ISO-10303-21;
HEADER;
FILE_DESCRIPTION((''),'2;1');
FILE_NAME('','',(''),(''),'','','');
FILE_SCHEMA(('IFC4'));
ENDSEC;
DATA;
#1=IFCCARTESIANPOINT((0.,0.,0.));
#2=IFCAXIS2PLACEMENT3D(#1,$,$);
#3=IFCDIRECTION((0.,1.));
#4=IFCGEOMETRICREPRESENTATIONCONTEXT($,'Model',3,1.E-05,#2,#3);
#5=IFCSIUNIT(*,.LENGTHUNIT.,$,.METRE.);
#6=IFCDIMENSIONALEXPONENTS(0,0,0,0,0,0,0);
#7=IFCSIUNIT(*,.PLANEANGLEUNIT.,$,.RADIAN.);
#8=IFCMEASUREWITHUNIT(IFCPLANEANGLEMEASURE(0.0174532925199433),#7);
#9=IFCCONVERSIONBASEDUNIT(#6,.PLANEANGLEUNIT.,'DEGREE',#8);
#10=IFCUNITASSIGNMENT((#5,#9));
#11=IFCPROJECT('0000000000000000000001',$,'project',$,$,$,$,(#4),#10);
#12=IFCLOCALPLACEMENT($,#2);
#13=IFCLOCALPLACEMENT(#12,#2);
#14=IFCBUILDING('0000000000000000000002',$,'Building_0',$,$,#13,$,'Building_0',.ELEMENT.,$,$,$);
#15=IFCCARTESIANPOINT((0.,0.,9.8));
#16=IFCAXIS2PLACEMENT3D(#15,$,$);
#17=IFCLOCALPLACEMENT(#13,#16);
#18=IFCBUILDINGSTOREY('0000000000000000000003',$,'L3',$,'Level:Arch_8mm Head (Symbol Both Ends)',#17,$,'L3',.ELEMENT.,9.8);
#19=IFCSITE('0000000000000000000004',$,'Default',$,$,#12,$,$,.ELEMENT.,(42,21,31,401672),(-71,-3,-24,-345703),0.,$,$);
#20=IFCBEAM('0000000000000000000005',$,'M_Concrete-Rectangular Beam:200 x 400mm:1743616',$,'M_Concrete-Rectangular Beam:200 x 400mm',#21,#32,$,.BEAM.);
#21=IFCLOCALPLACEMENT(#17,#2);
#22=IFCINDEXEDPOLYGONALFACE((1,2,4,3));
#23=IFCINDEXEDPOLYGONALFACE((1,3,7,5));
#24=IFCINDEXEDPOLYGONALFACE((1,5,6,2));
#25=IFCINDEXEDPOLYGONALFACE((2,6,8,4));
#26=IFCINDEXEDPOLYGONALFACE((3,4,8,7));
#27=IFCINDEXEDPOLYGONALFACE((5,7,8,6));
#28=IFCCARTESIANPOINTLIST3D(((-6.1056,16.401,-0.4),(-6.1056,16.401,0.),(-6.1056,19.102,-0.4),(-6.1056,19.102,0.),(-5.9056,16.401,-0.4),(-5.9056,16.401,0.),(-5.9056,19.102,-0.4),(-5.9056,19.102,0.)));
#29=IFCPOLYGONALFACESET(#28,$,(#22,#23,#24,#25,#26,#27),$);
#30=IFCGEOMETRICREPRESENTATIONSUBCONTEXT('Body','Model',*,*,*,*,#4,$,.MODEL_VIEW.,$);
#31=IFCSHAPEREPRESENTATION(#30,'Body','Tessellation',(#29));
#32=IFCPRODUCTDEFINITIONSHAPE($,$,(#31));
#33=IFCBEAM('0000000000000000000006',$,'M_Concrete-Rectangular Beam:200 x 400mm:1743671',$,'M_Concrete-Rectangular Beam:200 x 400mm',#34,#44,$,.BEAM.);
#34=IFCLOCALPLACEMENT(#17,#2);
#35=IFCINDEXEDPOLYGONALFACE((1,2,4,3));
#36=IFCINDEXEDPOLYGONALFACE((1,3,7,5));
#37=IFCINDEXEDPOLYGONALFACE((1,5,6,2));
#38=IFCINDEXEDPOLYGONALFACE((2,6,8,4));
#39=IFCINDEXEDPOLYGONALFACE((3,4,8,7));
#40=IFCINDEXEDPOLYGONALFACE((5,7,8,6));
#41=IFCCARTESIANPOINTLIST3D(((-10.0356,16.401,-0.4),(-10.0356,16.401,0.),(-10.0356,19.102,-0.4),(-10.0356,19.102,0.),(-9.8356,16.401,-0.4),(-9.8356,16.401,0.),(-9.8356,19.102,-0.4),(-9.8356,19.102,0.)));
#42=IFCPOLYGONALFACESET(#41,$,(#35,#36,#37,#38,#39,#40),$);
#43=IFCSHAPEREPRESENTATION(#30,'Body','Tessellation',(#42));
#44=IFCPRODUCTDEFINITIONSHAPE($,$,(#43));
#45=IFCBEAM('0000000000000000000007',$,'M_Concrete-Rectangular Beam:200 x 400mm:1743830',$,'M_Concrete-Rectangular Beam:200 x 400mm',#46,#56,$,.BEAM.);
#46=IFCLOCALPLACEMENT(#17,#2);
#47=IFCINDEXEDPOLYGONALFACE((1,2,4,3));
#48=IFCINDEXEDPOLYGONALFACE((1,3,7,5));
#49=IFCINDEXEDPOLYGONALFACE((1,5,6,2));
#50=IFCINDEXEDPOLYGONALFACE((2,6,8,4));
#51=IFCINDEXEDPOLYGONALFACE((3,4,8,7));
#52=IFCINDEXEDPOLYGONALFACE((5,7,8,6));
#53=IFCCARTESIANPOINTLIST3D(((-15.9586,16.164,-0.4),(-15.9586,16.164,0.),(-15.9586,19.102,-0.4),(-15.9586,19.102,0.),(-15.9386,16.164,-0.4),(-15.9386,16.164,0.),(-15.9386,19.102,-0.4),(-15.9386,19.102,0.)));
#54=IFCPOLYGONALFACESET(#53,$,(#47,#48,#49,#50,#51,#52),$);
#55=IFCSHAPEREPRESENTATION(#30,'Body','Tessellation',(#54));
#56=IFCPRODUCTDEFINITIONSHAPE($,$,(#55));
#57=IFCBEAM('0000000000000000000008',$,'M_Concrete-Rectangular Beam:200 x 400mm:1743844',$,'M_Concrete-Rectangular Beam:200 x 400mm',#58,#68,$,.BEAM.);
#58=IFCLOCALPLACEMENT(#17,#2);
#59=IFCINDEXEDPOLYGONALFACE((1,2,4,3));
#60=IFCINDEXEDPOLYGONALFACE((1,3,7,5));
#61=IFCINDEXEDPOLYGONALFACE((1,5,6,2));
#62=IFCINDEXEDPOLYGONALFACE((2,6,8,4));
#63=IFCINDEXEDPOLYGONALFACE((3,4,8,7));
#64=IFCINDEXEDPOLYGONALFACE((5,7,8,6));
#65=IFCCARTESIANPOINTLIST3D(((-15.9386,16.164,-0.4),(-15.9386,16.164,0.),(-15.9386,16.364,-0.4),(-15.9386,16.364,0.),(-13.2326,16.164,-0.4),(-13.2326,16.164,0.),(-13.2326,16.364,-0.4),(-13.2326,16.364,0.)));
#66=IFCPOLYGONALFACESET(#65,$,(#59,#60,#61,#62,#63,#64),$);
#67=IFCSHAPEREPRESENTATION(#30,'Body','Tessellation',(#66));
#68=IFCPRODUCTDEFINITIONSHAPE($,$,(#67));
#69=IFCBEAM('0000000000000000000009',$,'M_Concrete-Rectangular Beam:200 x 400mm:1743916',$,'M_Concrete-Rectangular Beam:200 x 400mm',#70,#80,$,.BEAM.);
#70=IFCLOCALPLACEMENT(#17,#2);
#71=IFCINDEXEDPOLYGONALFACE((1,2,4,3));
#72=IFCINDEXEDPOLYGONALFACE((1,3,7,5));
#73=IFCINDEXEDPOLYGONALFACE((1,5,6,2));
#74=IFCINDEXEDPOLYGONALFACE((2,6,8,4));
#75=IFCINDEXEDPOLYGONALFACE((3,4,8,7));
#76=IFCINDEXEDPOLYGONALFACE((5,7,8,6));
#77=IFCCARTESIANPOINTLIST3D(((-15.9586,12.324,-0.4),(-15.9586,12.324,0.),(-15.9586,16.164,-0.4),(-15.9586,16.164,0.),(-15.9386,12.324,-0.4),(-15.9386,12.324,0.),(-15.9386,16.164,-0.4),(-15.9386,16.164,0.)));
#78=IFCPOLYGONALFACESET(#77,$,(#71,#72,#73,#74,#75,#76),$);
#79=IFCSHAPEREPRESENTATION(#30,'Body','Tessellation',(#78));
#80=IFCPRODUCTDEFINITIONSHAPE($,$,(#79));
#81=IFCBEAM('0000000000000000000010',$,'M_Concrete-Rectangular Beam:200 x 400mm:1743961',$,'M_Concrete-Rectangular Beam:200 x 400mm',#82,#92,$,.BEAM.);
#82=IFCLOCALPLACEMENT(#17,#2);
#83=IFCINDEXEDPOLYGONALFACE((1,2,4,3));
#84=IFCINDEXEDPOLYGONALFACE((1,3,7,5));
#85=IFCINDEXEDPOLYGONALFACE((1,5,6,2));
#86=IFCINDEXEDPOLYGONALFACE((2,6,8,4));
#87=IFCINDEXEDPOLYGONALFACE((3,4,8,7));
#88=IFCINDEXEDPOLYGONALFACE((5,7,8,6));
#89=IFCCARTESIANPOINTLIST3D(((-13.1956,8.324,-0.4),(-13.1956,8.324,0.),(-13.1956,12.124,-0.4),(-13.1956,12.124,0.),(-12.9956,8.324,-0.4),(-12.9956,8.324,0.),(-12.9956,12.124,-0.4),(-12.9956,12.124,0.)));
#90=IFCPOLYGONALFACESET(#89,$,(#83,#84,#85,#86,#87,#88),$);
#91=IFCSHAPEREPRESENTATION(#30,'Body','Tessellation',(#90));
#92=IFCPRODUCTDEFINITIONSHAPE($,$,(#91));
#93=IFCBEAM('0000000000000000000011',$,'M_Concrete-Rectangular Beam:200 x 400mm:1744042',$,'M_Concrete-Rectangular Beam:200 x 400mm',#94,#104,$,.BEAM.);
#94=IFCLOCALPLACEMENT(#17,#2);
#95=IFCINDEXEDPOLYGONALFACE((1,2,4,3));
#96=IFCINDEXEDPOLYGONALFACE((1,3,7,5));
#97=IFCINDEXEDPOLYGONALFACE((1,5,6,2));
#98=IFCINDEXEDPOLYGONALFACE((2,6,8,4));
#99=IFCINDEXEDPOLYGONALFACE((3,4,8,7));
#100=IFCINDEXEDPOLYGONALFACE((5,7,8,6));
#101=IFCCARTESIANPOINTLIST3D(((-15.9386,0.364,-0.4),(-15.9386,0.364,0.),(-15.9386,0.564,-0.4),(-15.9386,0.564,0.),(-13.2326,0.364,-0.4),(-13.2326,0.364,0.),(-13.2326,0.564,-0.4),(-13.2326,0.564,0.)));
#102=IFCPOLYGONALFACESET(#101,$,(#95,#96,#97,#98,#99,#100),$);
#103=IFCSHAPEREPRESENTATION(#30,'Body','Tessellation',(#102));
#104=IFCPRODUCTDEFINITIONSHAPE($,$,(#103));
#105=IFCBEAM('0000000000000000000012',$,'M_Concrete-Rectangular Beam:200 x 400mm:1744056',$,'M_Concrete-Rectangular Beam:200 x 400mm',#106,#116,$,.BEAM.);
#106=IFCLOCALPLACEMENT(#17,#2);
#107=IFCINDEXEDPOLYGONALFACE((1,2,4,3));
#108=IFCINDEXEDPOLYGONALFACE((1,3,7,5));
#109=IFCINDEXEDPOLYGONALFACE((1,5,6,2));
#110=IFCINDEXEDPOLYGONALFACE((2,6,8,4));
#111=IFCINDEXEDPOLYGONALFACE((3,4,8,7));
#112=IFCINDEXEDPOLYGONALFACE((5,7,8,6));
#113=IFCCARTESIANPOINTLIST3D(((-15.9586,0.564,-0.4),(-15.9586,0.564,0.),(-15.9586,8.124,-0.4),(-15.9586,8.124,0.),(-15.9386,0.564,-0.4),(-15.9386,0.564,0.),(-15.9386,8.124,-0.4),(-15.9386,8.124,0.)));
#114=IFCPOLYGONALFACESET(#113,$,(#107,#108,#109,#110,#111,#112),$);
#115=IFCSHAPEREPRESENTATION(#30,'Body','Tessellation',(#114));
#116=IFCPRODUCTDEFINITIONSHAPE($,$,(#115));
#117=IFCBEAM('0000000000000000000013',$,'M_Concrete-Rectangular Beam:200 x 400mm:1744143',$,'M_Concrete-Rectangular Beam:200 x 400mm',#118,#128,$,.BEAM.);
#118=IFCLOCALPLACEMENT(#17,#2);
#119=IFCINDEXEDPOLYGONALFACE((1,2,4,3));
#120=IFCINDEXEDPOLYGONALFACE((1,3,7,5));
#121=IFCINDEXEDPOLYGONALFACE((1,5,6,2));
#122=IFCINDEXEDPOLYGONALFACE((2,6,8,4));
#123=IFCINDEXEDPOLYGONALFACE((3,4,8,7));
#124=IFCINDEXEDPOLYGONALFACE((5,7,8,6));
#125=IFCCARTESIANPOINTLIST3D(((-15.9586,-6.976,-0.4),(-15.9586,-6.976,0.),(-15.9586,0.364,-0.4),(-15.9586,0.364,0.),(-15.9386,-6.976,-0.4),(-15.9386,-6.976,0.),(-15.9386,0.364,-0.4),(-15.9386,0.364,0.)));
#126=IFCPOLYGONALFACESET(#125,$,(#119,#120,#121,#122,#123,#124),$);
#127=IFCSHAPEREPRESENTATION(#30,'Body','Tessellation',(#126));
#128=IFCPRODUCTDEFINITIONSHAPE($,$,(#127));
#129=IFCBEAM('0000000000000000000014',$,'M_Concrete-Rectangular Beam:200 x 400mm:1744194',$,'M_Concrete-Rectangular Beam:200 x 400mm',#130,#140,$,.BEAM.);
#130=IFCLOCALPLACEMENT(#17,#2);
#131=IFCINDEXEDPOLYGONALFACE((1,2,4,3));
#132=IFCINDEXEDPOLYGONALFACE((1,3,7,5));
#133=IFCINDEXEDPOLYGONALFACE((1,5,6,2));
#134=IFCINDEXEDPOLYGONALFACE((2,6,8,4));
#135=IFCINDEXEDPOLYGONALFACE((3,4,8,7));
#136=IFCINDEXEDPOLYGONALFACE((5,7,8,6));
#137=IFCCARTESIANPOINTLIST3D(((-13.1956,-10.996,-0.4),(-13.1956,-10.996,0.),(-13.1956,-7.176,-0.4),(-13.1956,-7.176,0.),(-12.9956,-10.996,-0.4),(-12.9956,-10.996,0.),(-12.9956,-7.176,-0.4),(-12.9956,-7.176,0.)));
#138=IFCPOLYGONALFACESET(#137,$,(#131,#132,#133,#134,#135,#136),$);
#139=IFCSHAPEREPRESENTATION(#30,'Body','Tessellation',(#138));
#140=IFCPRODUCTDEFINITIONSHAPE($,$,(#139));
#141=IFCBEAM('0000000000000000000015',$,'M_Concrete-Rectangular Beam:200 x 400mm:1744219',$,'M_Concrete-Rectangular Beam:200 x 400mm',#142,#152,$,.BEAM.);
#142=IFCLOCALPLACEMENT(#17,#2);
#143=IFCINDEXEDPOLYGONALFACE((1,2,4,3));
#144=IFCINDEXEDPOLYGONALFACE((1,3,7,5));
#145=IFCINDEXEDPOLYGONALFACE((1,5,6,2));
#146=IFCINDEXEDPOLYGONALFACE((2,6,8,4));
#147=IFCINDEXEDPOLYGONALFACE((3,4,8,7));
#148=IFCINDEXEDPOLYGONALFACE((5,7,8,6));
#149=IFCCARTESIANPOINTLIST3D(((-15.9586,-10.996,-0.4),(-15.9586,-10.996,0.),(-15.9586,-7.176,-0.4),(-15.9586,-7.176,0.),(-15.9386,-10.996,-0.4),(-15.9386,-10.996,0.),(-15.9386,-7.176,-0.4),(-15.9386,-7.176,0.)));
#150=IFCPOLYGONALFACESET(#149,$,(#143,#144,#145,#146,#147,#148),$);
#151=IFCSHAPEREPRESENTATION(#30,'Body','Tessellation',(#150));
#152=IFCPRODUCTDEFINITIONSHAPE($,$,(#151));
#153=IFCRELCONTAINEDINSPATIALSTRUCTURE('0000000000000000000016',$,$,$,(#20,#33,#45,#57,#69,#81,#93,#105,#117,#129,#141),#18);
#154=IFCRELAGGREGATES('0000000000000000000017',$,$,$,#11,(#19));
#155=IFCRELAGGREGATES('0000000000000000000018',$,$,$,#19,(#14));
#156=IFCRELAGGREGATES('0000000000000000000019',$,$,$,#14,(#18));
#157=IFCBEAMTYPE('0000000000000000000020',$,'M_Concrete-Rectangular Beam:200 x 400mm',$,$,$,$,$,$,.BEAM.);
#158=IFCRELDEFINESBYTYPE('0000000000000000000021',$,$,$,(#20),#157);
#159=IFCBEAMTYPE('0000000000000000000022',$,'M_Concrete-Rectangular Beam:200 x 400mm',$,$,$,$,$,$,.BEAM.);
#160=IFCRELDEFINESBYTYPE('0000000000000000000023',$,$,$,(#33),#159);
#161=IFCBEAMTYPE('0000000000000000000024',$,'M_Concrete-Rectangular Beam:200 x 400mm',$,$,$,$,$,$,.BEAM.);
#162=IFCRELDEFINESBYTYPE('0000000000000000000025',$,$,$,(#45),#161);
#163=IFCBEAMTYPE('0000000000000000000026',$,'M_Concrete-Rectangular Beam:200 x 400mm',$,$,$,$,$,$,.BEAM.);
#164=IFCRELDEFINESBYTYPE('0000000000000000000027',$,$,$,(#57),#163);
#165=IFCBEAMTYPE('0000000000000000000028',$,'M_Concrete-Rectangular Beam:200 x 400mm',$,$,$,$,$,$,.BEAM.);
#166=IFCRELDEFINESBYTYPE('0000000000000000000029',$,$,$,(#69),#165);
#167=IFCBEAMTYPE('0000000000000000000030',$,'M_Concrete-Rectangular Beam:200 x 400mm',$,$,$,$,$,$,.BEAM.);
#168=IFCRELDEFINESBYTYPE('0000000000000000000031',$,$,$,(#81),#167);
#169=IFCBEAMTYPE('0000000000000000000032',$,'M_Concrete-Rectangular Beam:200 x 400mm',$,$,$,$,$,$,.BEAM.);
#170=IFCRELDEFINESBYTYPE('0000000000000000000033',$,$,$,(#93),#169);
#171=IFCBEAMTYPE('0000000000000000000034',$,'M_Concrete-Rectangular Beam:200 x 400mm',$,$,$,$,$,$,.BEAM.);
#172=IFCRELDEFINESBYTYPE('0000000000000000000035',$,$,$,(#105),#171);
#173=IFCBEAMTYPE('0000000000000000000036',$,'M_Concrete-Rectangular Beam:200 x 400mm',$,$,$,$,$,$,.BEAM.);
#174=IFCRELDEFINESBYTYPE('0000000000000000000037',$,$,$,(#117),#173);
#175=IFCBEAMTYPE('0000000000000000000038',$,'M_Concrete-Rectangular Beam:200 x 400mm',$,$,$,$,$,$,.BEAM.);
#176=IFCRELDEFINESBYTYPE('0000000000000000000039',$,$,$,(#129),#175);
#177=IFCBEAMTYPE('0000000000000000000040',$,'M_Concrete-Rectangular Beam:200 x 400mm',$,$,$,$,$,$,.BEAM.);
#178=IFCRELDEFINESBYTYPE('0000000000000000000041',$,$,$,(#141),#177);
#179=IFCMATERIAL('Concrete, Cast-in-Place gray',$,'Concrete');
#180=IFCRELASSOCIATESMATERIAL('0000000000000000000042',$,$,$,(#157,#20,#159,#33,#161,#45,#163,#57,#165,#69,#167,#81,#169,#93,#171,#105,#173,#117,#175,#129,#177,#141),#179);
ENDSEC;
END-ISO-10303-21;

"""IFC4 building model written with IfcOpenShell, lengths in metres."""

from ifc_helpers import new_model, entity, si_unit, converted_unit, direction, frame, origin, place, context, subcontext, project, spatial, indexed_curve, outline, extrude, source, transform, mapped, material, type_object, type_shapes, element, save


model = new_model("IFC4")

# Units and contexts
model_context = context("Model", 3, precision=1e-05, world=origin(), true_north=direction((0.0, 1.0)))
body_context = subcontext(model_context, "Body", "Model", "MODEL_VIEW")
ifc_project = project(units=[si_unit("LENGTHUNIT", "METRE"), converted_unit("PLANEANGLEUNIT", "DEGREE", entity("IfcPlaneAngleMeasure", 0.0174532925199433), si_unit("PLANEANGLEUNIT", "RADIAN"), dimensions=[0, 0, 0, 0, 0, 0, 0])], contexts=[model_context])

# Site, building, storey
site_placement = place(None, origin())
site = spatial("IfcSite", under=ifc_project, at=site_placement, Name="Default", CompositionType="ELEMENT", RefLatitude=(42, 21, 31, 401672), RefLongitude=(-71, -3, -24, -345703), RefElevation=0.0)
building_placement = place(site_placement, origin())
building = spatial("IfcBuilding", under=site, at=building_placement, Name="Building_0", LongName="Building_0", CompositionType="ELEMENT")
storey_placement = place(building_placement, frame((0.0, 0.0, 9.8)))
storey = spatial("IfcBuildingStorey", under=building, at=storey_placement, Name="L3", ObjectType="Level:Arch_8mm Head (Symbol Both Ends)", LongName="L3", CompositionType="ELEMENT", Elevation=9.8)

# Beams
ifc_material = material(Name="Concrete, Cast-in-Place gray", Category="Concrete")
beam_type_1 = type_object("IfcBeamType", Name="M_Concrete-Rectangular Beam:200 x 400mm", PredefinedType="BEAM", material=ifc_material)
shared_shape_1 = source(origin(), body_context, "Body", "SweptSolid", [
    extrude(outline(indexed_curve([(-0.1, -0.2), (0.1, -0.2), (0.1, 0.2), (-0.1, 0.2), (-0.1, -0.2)], self_intersect=False)), frame((-6.0056, 16.401, 9.6), z_axis=(0.0, 1.0, 0.0), x_axis=(-1.0, 0.0, 0.0)), (0.0, 0.0, 1.0), 2.701),
])
type_shapes(beam_type_1, [shared_shape_1])
beam_1_placement = place(storey_placement, frame((0.0, 0.0, -9.8)))
element("IfcBeam", 1, at=beam_1_placement, inside=storey, type_object=beam_type_1, material=ifc_material, Name="M_Concrete-Rectangular Beam:200 x 400mm:1743616", ObjectType="M_Concrete-Rectangular Beam:200 x 400mm", PredefinedType="BEAM", context=body_context, shape_type="MappedRepresentation", body=[
    mapped(shared_shape_1, transform((0.0, 0.0, 0.0), scale=1.0)),
])
beam_type_2 = type_object("IfcBeamType", Name="M_Concrete-Rectangular Beam:200 x 400mm", PredefinedType="BEAM", material=ifc_material)
shared_shape_2 = source(origin(), body_context, "Body", "SweptSolid", [
    extrude(outline(indexed_curve([(-0.1, -0.2), (0.1, -0.2), (0.1, 0.2), (-0.1, 0.2), (-0.1, -0.2)], self_intersect=False)), frame((-9.9356, 16.401, 9.6), z_axis=(0.0, 1.0, 0.0), x_axis=(-1.0, 0.0, 0.0)), (0.0, 0.0, 1.0), 2.701),
])
type_shapes(beam_type_2, [shared_shape_2])
beam_2_placement = place(storey_placement, frame((0.0, 0.0, -9.8)))
element("IfcBeam", 2, at=beam_2_placement, inside=storey, type_object=beam_type_2, material=ifc_material, Name="M_Concrete-Rectangular Beam:200 x 400mm:1743671", ObjectType="M_Concrete-Rectangular Beam:200 x 400mm", PredefinedType="BEAM", context=body_context, shape_type="MappedRepresentation", body=[
    mapped(shared_shape_2, transform((0.0, 0.0, 0.0), scale=1.0)),
])
beam_type_3 = type_object("IfcBeamType", Name="M_Concrete-Rectangular Beam:200 x 400mm", PredefinedType="BEAM", material=ifc_material)
shared_shape_3 = source(origin(), body_context, "Body", "SweptSolid", [
    extrude(outline(indexed_curve([(-0.01, -0.2), (0.01, -0.2), (0.01, 0.2), (-0.01, 0.2), (-0.01, -0.2)], self_intersect=False)), frame((-15.9486, 19.102, 9.6), z_axis=(0.0, -1.0, 0.0), x_axis=(-1.0, 0.0, 0.0)), (0.0, 0.0, 1.0), 2.938),
])
type_shapes(beam_type_3, [shared_shape_3])
beam_3_placement = place(storey_placement, frame((0.0, 0.0, -9.8)))
element("IfcBeam", 3, at=beam_3_placement, inside=storey, type_object=beam_type_3, material=ifc_material, Name="M_Concrete-Rectangular Beam:200 x 400mm:1743830", ObjectType="M_Concrete-Rectangular Beam:200 x 400mm", PredefinedType="BEAM", context=body_context, shape_type="MappedRepresentation", body=[
    mapped(shared_shape_3, transform((0.0, 0.0, 0.0), scale=1.0)),
])
beam_type_4 = type_object("IfcBeamType", Name="M_Concrete-Rectangular Beam:200 x 400mm", PredefinedType="BEAM", material=ifc_material)
shared_shape_4 = source(origin(), body_context, "Body", "SweptSolid", [
    extrude(outline(indexed_curve([(-0.2, -0.1), (0.2, -0.1), (0.2, 0.1), (-0.2, 0.1), (-0.2, -0.1)], self_intersect=False)), frame((-15.9386, 16.264, 9.6), z_axis=(1.0, 0.0, 0.0), x_axis=(0.0, 0.0, -1.0)), (0.0, 0.0, 1.0), 2.706),
])
type_shapes(beam_type_4, [shared_shape_4])
beam_4_placement = place(storey_placement, frame((0.0, 0.0, -9.8)))
element("IfcBeam", 4, at=beam_4_placement, inside=storey, type_object=beam_type_4, material=ifc_material, Name="M_Concrete-Rectangular Beam:200 x 400mm:1743844", ObjectType="M_Concrete-Rectangular Beam:200 x 400mm", PredefinedType="BEAM", context=body_context, shape_type="MappedRepresentation", body=[
    mapped(shared_shape_4, transform((0.0, 0.0, 0.0), scale=1.0)),
])
beam_type_5 = type_object("IfcBeamType", Name="M_Concrete-Rectangular Beam:200 x 400mm", PredefinedType="BEAM", material=ifc_material)
shared_shape_5 = source(origin(), body_context, "Body", "SweptSolid", [
    extrude(outline(indexed_curve([(-0.01, -0.2), (0.01, -0.2), (0.01, 0.2), (-0.01, 0.2), (-0.01, -0.2)], self_intersect=False)), frame((-15.9486, 12.324, 9.6), z_axis=(0.0, 1.0, 0.0), x_axis=(-1.0, 0.0, 0.0)), (0.0, 0.0, 1.0), 3.84),
])
type_shapes(beam_type_5, [shared_shape_5])
beam_5_placement = place(storey_placement, frame((0.0, 0.0, -9.8)))
element("IfcBeam", 5, at=beam_5_placement, inside=storey, type_object=beam_type_5, material=ifc_material, Name="M_Concrete-Rectangular Beam:200 x 400mm:1743916", ObjectType="M_Concrete-Rectangular Beam:200 x 400mm", PredefinedType="BEAM", context=body_context, shape_type="MappedRepresentation", body=[
    mapped(shared_shape_5, transform((0.0, 0.0, 0.0), scale=1.0)),
])
beam_type_6 = type_object("IfcBeamType", Name="M_Concrete-Rectangular Beam:200 x 400mm", PredefinedType="BEAM", material=ifc_material)
shared_shape_6 = source(origin(), body_context, "Body", "SweptSolid", [
    extrude(outline(indexed_curve([(-0.1, -0.2), (0.1, -0.2), (0.1, 0.2), (-0.1, 0.2), (-0.1, -0.2)], self_intersect=False)), frame((-13.0956, 12.124, 9.6), z_axis=(0.0, -1.0, 0.0), x_axis=(-1.0, 0.0, 0.0)), (0.0, 0.0, 1.0), 3.8),
])
type_shapes(beam_type_6, [shared_shape_6])
beam_6_placement = place(storey_placement, frame((0.0, 0.0, -9.8)))
element("IfcBeam", 6, at=beam_6_placement, inside=storey, type_object=beam_type_6, material=ifc_material, Name="M_Concrete-Rectangular Beam:200 x 400mm:1743961", ObjectType="M_Concrete-Rectangular Beam:200 x 400mm", PredefinedType="BEAM", context=body_context, shape_type="MappedRepresentation", body=[
    mapped(shared_shape_6, transform((0.0, 0.0, 0.0), scale=1.0)),
])
beam_type_7 = type_object("IfcBeamType", Name="M_Concrete-Rectangular Beam:200 x 400mm", PredefinedType="BEAM", material=ifc_material)
shared_shape_7 = source(origin(), body_context, "Body", "SweptSolid", [
    extrude(outline(indexed_curve([(-0.2, -0.1), (0.2, -0.1), (0.2, 0.1), (-0.2, 0.1), (-0.2, -0.1)], self_intersect=False)), frame((-13.2326, 0.464, 9.6), z_axis=(-1.0, 0.0, 0.0), x_axis=(0.0, 0.0, -1.0)), (0.0, 0.0, 1.0), 2.706),
])
type_shapes(beam_type_7, [shared_shape_7])
beam_7_placement = place(storey_placement, frame((0.0, 0.0, -9.8)))
element("IfcBeam", 7, at=beam_7_placement, inside=storey, type_object=beam_type_7, material=ifc_material, Name="M_Concrete-Rectangular Beam:200 x 400mm:1744042", ObjectType="M_Concrete-Rectangular Beam:200 x 400mm", PredefinedType="BEAM", context=body_context, shape_type="MappedRepresentation", body=[
    mapped(shared_shape_7, transform((0.0, 0.0, 0.0), scale=1.0)),
])
beam_type_8 = type_object("IfcBeamType", Name="M_Concrete-Rectangular Beam:200 x 400mm", PredefinedType="BEAM", material=ifc_material)
shared_shape_8 = source(origin(), body_context, "Body", "SweptSolid", [
    extrude(outline(indexed_curve([(-0.01, -0.2), (0.01, -0.2), (0.01, 0.2), (-0.01, 0.2), (-0.01, -0.2)], self_intersect=False)), frame((-15.9486, 0.564, 9.6), z_axis=(0.0, 1.0, 0.0), x_axis=(-1.0, 0.0, 0.0)), (0.0, 0.0, 1.0), 7.56),
])
type_shapes(beam_type_8, [shared_shape_8])
beam_8_placement = place(storey_placement, frame((0.0, 0.0, -9.8)))
element("IfcBeam", 8, at=beam_8_placement, inside=storey, type_object=beam_type_8, material=ifc_material, Name="M_Concrete-Rectangular Beam:200 x 400mm:1744056", ObjectType="M_Concrete-Rectangular Beam:200 x 400mm", PredefinedType="BEAM", context=body_context, shape_type="MappedRepresentation", body=[
    mapped(shared_shape_8, transform((0.0, 0.0, 0.0), scale=1.0)),
])
beam_type_9 = type_object("IfcBeamType", Name="M_Concrete-Rectangular Beam:200 x 400mm", PredefinedType="BEAM", material=ifc_material)
shared_shape_9 = source(origin(), body_context, "Body", "SweptSolid", [
    extrude(outline(indexed_curve([(-0.01, -0.2), (0.01, -0.2), (0.01, 0.2), (-0.01, 0.2), (-0.01, -0.2)], self_intersect=False)), frame((-15.9486, -6.976, 9.6), z_axis=(0.0, 1.0, 0.0), x_axis=(-1.0, 0.0, 0.0)), (0.0, 0.0, 1.0), 7.34),
])
type_shapes(beam_type_9, [shared_shape_9])
beam_9_placement = place(storey_placement, frame((0.0, 0.0, -9.8)))
element("IfcBeam", 9, at=beam_9_placement, inside=storey, type_object=beam_type_9, material=ifc_material, Name="M_Concrete-Rectangular Beam:200 x 400mm:1744143", ObjectType="M_Concrete-Rectangular Beam:200 x 400mm", PredefinedType="BEAM", context=body_context, shape_type="MappedRepresentation", body=[
    mapped(shared_shape_9, transform((0.0, 0.0, 0.0), scale=1.0)),
])
beam_type_10 = type_object("IfcBeamType", Name="M_Concrete-Rectangular Beam:200 x 400mm", PredefinedType="BEAM", material=ifc_material)
shared_shape_10 = source(origin(), body_context, "Body", "SweptSolid", [
    extrude(outline(indexed_curve([(-0.1, -0.2), (0.1, -0.2), (0.1, 0.2), (-0.1, 0.2), (-0.1, -0.2)], self_intersect=False)), frame((-13.0956, -7.176, 9.6), z_axis=(0.0, -1.0, 0.0), x_axis=(-1.0, 0.0, 0.0)), (0.0, 0.0, 1.0), 3.82),
])
type_shapes(beam_type_10, [shared_shape_10])
beam_10_placement = place(storey_placement, frame((0.0, 0.0, -9.8)))
element("IfcBeam", 10, at=beam_10_placement, inside=storey, type_object=beam_type_10, material=ifc_material, Name="M_Concrete-Rectangular Beam:200 x 400mm:1744194", ObjectType="M_Concrete-Rectangular Beam:200 x 400mm", PredefinedType="BEAM", context=body_context, shape_type="MappedRepresentation", body=[
    mapped(shared_shape_10, transform((0.0, 0.0, 0.0), scale=1.0)),
])
beam_type_11 = type_object("IfcBeamType", Name="M_Concrete-Rectangular Beam:200 x 400mm", PredefinedType="BEAM", material=ifc_material)
shared_shape_11 = source(origin(), body_context, "Body", "SweptSolid", [
    extrude(outline(indexed_curve([(-0.01, -0.2), (0.01, -0.2), (0.01, 0.2), (-0.01, 0.2), (-0.01, -0.2)], self_intersect=False)), frame((-15.9486, -10.996, 9.6), z_axis=(0.0, 1.0, 0.0), x_axis=(-1.0, 0.0, 0.0)), (0.0, 0.0, 1.0), 3.82),
])
type_shapes(beam_type_11, [shared_shape_11])
beam_11_placement = place(storey_placement, frame((0.0, 0.0, -9.8)))
element("IfcBeam", 11, at=beam_11_placement, inside=storey, type_object=beam_type_11, material=ifc_material, Name="M_Concrete-Rectangular Beam:200 x 400mm:1744219", ObjectType="M_Concrete-Rectangular Beam:200 x 400mm", PredefinedType="BEAM", context=body_context, shape_type="MappedRepresentation", body=[
    mapped(shared_shape_11, transform((0.0, 0.0, 0.0), scale=1.0)),
])

save(model, "model.ifc")
